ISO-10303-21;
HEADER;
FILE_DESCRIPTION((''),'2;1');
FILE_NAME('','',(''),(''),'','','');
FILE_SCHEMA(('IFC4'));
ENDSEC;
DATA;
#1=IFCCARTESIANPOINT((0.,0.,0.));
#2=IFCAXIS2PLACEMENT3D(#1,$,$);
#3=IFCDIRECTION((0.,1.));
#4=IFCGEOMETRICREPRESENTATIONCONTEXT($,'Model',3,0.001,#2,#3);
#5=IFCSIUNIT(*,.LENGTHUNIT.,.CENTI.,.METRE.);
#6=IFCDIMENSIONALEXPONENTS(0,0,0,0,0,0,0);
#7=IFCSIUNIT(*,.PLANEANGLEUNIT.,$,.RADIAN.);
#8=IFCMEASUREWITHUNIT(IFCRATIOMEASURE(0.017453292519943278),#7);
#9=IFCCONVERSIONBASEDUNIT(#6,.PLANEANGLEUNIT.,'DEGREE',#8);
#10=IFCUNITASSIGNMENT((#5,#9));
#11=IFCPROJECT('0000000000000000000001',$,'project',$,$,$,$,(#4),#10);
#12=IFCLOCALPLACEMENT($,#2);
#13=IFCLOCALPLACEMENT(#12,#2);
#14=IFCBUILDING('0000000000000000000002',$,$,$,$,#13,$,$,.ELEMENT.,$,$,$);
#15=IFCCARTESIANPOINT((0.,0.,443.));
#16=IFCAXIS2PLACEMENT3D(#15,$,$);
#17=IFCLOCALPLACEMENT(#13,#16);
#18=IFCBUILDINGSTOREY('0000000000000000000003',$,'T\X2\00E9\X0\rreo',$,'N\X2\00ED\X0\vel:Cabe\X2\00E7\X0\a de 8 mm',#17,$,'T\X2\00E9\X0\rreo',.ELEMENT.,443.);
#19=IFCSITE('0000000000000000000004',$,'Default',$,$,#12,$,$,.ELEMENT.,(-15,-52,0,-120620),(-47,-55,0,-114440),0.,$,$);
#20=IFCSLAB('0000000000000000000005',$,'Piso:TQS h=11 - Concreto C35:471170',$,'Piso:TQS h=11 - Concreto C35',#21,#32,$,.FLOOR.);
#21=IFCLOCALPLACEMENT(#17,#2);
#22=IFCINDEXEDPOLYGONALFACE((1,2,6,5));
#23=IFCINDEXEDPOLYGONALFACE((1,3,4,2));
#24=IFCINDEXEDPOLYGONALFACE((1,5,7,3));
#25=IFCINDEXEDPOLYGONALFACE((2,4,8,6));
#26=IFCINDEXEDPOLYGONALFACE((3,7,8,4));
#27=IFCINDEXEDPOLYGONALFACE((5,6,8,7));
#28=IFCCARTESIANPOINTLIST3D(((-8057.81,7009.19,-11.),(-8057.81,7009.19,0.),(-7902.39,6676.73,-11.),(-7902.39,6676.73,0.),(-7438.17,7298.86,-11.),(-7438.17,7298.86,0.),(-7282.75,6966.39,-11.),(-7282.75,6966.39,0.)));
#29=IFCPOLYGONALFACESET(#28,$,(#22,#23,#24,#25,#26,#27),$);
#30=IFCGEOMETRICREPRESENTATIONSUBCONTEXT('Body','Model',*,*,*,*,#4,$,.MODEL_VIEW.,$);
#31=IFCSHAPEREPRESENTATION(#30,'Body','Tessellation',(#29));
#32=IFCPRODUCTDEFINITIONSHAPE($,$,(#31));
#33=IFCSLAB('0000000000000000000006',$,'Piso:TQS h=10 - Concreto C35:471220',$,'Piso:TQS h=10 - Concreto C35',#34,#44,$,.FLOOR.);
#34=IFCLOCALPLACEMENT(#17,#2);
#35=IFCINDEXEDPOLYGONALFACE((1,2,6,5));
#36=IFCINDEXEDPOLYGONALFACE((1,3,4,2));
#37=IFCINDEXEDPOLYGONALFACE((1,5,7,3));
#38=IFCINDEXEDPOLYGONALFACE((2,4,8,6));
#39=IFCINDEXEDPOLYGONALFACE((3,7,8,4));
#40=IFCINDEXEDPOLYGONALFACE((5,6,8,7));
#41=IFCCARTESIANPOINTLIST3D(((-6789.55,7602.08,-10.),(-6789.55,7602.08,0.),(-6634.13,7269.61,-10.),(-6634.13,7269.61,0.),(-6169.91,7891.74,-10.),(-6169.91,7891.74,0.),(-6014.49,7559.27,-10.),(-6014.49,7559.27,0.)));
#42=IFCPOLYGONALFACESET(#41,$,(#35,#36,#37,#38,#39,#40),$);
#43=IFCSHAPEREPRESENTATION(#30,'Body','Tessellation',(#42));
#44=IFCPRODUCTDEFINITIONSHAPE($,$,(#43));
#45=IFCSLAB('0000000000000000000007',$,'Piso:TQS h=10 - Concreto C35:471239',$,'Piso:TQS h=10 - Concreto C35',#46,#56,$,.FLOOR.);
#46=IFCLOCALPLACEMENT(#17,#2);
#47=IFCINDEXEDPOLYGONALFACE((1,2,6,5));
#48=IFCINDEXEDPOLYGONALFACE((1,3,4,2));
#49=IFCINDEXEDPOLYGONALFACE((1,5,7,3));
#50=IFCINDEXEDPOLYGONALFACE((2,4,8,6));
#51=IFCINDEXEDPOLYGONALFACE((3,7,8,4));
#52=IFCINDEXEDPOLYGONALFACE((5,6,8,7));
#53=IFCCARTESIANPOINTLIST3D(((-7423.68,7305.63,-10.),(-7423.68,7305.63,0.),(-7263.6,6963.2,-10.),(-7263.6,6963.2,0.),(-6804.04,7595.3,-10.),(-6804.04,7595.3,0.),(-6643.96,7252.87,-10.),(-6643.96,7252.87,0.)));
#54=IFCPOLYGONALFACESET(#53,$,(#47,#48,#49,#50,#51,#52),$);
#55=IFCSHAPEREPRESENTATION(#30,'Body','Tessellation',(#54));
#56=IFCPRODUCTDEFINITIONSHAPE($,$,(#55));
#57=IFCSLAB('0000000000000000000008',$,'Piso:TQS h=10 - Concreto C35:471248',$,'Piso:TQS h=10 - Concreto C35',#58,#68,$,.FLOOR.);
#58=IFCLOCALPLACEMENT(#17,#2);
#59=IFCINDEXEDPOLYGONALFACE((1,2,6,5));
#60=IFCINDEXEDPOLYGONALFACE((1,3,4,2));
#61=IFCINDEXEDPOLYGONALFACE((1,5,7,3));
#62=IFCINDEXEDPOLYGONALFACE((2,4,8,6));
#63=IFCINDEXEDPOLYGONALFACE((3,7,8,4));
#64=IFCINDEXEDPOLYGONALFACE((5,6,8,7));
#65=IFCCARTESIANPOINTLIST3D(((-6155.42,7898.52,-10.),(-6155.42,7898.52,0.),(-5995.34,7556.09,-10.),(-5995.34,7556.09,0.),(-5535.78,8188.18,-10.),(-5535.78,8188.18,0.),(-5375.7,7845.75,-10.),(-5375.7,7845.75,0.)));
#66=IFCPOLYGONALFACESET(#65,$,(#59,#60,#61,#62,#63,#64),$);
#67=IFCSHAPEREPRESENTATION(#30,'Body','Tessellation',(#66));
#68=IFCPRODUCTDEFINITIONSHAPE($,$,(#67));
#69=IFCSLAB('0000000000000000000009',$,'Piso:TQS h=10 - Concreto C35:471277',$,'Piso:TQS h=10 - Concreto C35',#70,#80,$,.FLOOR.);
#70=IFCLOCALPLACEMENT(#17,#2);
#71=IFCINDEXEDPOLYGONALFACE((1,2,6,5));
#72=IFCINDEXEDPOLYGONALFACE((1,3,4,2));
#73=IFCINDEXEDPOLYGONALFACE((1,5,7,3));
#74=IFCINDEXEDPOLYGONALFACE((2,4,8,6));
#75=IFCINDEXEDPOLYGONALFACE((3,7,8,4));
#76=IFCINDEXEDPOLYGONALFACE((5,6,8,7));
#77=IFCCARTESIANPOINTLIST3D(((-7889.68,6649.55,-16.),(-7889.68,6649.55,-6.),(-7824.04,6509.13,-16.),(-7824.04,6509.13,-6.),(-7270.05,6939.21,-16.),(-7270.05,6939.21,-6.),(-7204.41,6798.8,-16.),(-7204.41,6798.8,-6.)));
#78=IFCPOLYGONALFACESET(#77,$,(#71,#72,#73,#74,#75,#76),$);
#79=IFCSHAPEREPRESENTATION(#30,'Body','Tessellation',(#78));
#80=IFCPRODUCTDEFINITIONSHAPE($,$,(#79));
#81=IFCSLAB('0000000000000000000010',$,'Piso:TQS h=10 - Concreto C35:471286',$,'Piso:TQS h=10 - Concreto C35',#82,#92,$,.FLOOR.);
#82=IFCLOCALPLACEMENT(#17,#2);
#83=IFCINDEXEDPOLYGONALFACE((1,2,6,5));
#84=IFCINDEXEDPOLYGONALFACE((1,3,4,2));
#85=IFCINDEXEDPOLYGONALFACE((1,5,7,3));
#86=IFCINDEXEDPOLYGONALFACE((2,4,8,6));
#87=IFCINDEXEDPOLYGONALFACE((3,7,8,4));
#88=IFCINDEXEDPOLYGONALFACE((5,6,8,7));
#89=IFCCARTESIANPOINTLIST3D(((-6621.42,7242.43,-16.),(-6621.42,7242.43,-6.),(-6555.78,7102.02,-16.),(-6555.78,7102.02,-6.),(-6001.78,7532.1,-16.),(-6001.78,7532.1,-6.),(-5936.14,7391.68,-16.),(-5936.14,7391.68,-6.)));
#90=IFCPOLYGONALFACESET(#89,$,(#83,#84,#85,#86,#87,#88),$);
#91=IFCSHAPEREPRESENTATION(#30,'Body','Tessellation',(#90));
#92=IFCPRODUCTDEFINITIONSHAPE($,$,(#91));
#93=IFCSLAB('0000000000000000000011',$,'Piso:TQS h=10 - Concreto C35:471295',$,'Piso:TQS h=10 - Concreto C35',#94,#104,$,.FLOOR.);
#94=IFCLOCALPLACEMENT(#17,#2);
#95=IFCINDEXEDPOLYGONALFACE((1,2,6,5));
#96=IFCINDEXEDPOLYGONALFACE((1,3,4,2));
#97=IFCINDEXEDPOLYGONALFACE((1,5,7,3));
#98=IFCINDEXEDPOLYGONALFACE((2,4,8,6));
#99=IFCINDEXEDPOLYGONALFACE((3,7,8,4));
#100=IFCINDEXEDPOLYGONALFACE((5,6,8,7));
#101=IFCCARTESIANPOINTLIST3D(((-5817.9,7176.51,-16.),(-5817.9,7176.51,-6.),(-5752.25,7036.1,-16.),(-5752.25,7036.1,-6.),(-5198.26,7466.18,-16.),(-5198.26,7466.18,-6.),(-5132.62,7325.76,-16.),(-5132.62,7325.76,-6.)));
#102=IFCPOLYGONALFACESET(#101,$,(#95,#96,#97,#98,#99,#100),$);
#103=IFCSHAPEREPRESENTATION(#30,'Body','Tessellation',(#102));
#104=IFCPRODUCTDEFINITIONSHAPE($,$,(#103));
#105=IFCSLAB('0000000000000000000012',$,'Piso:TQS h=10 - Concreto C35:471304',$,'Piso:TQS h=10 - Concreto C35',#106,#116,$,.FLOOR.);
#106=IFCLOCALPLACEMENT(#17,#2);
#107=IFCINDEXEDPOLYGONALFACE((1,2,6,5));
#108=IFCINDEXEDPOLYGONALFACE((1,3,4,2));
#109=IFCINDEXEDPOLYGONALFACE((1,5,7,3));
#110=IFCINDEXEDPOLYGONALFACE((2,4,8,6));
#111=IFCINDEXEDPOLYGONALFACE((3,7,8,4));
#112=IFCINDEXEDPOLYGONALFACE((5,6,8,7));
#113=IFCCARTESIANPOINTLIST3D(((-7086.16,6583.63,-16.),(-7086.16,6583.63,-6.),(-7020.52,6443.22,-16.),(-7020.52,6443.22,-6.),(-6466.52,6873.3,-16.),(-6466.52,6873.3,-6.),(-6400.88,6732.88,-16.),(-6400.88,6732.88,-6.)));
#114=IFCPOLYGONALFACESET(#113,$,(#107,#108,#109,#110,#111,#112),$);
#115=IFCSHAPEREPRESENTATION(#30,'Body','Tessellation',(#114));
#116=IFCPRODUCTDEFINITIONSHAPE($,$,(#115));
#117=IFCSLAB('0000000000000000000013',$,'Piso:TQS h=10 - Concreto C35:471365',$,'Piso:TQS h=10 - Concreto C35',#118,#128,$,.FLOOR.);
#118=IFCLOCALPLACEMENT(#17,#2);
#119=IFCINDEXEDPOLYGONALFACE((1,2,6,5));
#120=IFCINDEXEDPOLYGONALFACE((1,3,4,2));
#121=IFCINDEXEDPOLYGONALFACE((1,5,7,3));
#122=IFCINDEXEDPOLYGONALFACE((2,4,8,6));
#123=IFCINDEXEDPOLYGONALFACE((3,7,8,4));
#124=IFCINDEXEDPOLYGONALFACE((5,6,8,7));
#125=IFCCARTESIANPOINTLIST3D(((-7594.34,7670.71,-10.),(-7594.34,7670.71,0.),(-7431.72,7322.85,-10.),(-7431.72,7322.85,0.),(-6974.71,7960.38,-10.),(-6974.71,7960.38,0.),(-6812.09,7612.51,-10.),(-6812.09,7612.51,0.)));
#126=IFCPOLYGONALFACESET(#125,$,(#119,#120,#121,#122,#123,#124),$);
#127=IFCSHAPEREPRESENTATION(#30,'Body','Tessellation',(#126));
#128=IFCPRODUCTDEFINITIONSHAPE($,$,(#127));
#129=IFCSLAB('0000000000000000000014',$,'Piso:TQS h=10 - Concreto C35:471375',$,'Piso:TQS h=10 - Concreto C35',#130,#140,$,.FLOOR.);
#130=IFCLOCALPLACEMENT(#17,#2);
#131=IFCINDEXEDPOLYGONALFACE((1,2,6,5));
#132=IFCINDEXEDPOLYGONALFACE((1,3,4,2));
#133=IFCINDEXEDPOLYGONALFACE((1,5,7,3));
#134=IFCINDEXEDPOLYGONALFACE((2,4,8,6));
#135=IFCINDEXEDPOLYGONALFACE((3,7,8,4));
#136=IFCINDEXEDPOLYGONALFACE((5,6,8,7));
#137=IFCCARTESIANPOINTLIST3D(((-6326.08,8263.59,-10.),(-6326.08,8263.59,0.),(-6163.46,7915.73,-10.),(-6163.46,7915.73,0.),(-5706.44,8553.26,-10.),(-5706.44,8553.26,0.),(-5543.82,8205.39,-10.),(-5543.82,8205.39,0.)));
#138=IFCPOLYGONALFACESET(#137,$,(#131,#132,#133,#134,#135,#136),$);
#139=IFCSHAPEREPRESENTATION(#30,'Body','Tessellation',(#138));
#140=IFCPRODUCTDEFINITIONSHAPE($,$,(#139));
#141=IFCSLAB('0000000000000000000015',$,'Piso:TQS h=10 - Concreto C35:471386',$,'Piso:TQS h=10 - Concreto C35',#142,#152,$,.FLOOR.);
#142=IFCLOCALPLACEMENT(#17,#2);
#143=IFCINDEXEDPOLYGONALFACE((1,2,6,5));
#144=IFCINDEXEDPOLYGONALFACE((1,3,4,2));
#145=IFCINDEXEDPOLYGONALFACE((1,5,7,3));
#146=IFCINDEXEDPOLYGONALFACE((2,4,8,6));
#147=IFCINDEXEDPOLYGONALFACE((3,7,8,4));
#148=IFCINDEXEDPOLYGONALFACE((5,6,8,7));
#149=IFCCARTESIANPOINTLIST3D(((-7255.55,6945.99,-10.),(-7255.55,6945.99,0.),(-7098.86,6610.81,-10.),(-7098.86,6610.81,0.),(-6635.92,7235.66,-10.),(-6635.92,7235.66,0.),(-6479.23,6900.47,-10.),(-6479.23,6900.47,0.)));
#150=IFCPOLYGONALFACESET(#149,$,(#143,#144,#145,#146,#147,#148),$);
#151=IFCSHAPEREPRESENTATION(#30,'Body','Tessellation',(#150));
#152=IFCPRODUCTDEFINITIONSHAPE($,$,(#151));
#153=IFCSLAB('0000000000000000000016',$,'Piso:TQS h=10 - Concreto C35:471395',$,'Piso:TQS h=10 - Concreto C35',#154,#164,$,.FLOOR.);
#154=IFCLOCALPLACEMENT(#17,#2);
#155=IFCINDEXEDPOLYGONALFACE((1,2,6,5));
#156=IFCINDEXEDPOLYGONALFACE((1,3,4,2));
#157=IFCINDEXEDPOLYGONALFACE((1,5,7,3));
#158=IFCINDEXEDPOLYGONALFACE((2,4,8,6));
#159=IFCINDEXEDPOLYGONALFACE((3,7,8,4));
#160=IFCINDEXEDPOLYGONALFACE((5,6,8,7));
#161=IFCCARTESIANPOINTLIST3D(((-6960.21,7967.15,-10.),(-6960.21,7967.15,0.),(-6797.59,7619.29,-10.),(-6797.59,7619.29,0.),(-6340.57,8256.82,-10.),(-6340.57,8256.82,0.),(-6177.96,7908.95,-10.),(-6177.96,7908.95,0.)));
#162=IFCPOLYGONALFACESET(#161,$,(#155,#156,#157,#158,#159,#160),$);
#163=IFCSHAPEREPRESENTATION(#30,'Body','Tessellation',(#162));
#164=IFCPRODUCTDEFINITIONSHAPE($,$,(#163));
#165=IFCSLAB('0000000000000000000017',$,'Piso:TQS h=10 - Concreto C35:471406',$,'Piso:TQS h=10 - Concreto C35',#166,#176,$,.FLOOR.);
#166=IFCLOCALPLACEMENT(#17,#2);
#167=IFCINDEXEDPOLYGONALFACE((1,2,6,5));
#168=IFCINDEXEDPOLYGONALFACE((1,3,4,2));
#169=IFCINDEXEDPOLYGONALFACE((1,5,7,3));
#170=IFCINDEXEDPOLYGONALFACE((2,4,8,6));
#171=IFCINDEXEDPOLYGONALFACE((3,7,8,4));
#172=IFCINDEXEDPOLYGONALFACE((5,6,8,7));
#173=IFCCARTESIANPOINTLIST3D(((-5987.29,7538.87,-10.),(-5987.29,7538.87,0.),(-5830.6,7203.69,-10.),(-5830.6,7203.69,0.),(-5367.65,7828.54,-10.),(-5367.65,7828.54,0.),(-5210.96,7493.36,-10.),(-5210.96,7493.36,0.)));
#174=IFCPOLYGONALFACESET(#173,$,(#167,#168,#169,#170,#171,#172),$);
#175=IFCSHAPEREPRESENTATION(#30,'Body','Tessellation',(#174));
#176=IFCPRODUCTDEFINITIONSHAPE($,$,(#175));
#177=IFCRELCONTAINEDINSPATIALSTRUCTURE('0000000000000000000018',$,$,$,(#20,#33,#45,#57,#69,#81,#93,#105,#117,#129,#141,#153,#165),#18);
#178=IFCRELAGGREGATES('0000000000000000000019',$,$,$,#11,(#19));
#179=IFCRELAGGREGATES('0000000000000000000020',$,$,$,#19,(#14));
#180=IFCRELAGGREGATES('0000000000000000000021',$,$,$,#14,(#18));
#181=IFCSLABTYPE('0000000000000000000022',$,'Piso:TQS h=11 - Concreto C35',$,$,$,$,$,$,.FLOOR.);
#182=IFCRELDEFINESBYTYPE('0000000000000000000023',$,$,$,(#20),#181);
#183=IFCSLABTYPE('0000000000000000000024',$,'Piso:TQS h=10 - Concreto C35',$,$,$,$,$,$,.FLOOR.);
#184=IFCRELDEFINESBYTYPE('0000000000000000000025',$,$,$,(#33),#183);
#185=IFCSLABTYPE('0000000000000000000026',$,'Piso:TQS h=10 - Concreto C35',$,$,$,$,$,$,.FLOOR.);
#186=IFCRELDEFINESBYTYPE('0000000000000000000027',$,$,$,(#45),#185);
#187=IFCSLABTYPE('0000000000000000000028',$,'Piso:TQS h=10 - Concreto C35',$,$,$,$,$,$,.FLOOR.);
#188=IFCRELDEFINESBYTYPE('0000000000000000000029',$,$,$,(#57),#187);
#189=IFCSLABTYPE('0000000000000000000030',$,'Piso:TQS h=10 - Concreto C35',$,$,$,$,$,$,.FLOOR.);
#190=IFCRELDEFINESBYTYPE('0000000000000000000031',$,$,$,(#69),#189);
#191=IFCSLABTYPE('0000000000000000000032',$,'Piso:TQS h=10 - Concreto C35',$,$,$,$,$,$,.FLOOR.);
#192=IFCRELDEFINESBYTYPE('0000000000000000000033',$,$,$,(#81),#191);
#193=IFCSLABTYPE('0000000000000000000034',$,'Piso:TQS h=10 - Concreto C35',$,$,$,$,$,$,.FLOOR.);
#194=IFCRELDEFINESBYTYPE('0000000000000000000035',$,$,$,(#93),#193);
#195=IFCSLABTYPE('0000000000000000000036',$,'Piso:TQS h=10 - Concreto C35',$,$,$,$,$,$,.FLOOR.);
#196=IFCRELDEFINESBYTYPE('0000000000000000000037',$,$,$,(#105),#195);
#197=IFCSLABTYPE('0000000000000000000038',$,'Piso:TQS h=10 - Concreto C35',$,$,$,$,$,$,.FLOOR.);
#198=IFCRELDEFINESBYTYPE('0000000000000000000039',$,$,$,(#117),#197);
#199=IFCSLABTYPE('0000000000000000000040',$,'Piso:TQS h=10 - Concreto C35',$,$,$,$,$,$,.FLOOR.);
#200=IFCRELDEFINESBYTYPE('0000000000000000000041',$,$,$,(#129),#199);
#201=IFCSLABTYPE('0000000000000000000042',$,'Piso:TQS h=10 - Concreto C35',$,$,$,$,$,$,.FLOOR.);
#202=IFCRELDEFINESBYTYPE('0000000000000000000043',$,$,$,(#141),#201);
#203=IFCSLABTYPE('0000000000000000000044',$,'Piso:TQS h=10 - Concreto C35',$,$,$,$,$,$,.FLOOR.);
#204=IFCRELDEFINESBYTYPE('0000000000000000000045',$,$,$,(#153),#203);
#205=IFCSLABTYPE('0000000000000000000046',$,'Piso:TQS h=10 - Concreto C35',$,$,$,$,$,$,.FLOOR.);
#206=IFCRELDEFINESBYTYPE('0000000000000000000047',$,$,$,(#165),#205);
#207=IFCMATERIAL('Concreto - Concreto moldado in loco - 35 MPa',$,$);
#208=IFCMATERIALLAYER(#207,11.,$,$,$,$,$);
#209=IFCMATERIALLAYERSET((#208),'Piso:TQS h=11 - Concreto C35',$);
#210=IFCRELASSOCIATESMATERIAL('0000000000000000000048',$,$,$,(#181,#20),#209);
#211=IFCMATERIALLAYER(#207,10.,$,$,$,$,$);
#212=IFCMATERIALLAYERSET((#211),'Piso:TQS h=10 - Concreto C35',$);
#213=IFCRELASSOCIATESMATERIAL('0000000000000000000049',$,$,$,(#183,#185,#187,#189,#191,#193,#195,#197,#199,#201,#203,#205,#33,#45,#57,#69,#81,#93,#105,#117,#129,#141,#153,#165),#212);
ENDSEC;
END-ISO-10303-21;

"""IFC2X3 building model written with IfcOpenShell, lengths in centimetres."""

from ifc_helpers import new_model, entity, si_unit, converted_unit, direction, frame, frame_2d, origin, origin_2d_with_axis, place, context, subcontext, project, spatial, rectangle, extrude, material, layer, layer_set, layer_usage, type_object, element, save


model = new_model("IFC2X3")

# Units and contexts
model_context = context("Model", 3, precision=0.001, world=origin(), true_north=direction((0.0, 1.0)))
body_context = subcontext(model_context, "Body", "Model", "MODEL_VIEW")
ifc_project = project(units=[si_unit("LENGTHUNIT", "METRE", prefix="CENTI"), converted_unit("PLANEANGLEUNIT", "DEGREE", entity("IfcRatioMeasure", 0.017453292519943278), si_unit("PLANEANGLEUNIT", "RADIAN"), dimensions=[0, 0, 0, 0, 0, 0, 0])], contexts=[model_context])

# Site, building, storey
site_placement = place(None, origin())
site = spatial("IfcSite", under=ifc_project, at=site_placement, Name="Default", CompositionType="ELEMENT", RefLatitude=(-15, -52, 0, -120620), RefLongitude=(-47, -55, 0, -114440), RefElevation=0.0)
building_placement = place(site_placement, origin())
building = spatial("IfcBuilding", under=site, at=building_placement, CompositionType="ELEMENT")
storey_placement = place(building_placement, frame((0.0, 0.0, 443.0)))
storey = spatial("IfcBuildingStorey", under=building, at=storey_placement, Name="Térreo", ObjectType="Nível:Cabeça de 8 mm", LongName="Térreo", CompositionType="ELEMENT", Elevation=443.0)

# Slabs
ifc_material = material(Name="Concreto - Concreto moldado in loco - 35 MPa")
ifc_layer_1 = layer(ifc_material, 11.0)
ifc_layer_set_1 = layer_set([ifc_layer_1], Name="Piso:TQS h=11 - Concreto C35")
ifc_layer_usage_1 = layer_usage(ifc_layer_set_1, "AXIS3", "POSITIVE", 0.0)
slab_type_1 = type_object("IfcSlabType", Name="Piso:TQS h=11 - Concreto C35", PredefinedType="FLOOR", material=ifc_layer_set_1)
slab_1_placement = place(storey_placement, origin())
element("IfcSlab", 1, at=slab_1_placement, inside=storey, type_object=slab_type_1, material=ifc_layer_usage_1, Name="Piso:TQS h=11 - Concreto C35:471170", ObjectType="Piso:TQS h=11 - Concreto C35", PredefinedType="FLOOR", context=body_context, shape_type="SweptSolid", body=[
    extrude(rectangle(XDim=367.0, YDim=684.0, at=frame_2d((0.0, 0.0), x_axis=(1.0, 0.0))), frame((-7670.28, 6987.79, 0.0), z_axis=(0.0, 0.0, -1.0), x_axis=(0.423488, -0.905902, 0.0)), (0.0, 0.0, 1.0), 11.0),
])
ifc_layer_2 = layer(ifc_material, 10.0)
ifc_layer_set_2 = layer_set([ifc_layer_2], Name="Piso:TQS h=10 - Concreto C35")
ifc_layer_usage_2 = layer_usage(ifc_layer_set_2, "AXIS3", "POSITIVE", 0.0)
slab_type_2 = type_object("IfcSlabType", Name="Piso:TQS h=10 - Concreto C35", PredefinedType="FLOOR", material=ifc_layer_set_2)
slab_2_placement = place(storey_placement, origin())
element("IfcSlab", 2, at=slab_2_placement, inside=storey, type_object=slab_type_2, material=ifc_layer_usage_2, Name="Piso:TQS h=10 - Concreto C35:471220", ObjectType="Piso:TQS h=10 - Concreto C35", PredefinedType="FLOOR", context=body_context, shape_type="SweptSolid", body=[
    extrude(rectangle(XDim=684.0, YDim=367.0, at=frame_2d((0.0, 0.0), x_axis=(1.0, 0.0))), frame((-6402.02, 7580.68, 0.0), z_axis=(0.0, 0.0, -1.0), x_axis=(0.905902, 0.423488, 0.0)), (0.0, 0.0, 1.0), 10.0),
])
ifc_layer_usage_3 = layer_usage(ifc_layer_set_2, "AXIS3", "POSITIVE", 0.0)
slab_type_3 = type_object("IfcSlabType", Name="Piso:TQS h=10 - Concreto C35", PredefinedType="FLOOR", material=ifc_layer_set_2)
slab_3_placement = place(storey_placement, origin())
element("IfcSlab", 3, at=slab_3_placement, inside=storey, type_object=slab_type_3, material=ifc_layer_usage_3, Name="Piso:TQS h=10 - Concreto C35:471239", ObjectType="Piso:TQS h=10 - Concreto C35", PredefinedType="FLOOR", context=body_context, shape_type="SweptSolid", body=[
    extrude(rectangle(XDim=684.0, YDim=378.0, at=origin_2d_with_axis()), frame((-7033.82, 7279.25, 0.0), z_axis=(0.0, 0.0, -1.0), x_axis=(0.905902, 0.423488, 0.0)), (0.0, 0.0, 1.0), 10.0),
])
ifc_layer_usage_4 = layer_usage(ifc_layer_set_2, "AXIS3", "POSITIVE", 0.0)
slab_type_4 = type_object("IfcSlabType", Name="Piso:TQS h=10 - Concreto C35", PredefinedType="FLOOR", material=ifc_layer_set_2)
slab_4_placement = place(storey_placement, origin())
element("IfcSlab", 4, at=slab_4_placement, inside=storey, type_object=slab_type_4, material=ifc_layer_usage_4, Name="Piso:TQS h=10 - Concreto C35:471248", ObjectType="Piso:TQS h=10 - Concreto C35", PredefinedType="FLOOR", context=body_context, shape_type="SweptSolid", body=[
    extrude(rectangle(XDim=684.0, YDim=378.0, at=frame_2d((0.0, 0.0), x_axis=(1.0, 0.0))), frame((-5765.56, 7872.13, 0.0), z_axis=(0.0, 0.0, -1.0), x_axis=(0.905902, 0.423488, 0.0)), (0.0, 0.0, 1.0), 10.0),
])
ifc_layer_usage_5 = layer_usage(ifc_layer_set_2, "AXIS3", "POSITIVE", 0.0)
slab_type_5 = type_object("IfcSlabType", Name="Piso:TQS h=10 - Concreto C35", PredefinedType="FLOOR", material=ifc_layer_set_2)
slab_5_placement = place(storey_placement, origin())
element("IfcSlab", 5, at=slab_5_placement, inside=storey, type_object=slab_type_5, material=ifc_layer_usage_5, Name="Piso:TQS h=10 - Concreto C35:471277", ObjectType="Piso:TQS h=10 - Concreto C35", PredefinedType="FLOOR", context=body_context, shape_type="SweptSolid", body=[
    extrude(rectangle(XDim=155.0, YDim=684.0, at=frame_2d((0.0, 0.0), x_axis=(1.0, 0.0))), frame((-7547.05, 6724.17, -6.0), z_axis=(0.0, 0.0, -1.0), x_axis=(0.423488, -0.905902, 0.0)), (0.0, 0.0, 1.0), 10.0),
])
ifc_layer_usage_6 = layer_usage(ifc_layer_set_2, "AXIS3", "POSITIVE", 0.0)
slab_type_6 = type_object("IfcSlabType", Name="Piso:TQS h=10 - Concreto C35", PredefinedType="FLOOR", material=ifc_layer_set_2)
slab_6_placement = place(storey_placement, origin())
element("IfcSlab", 6, at=slab_6_placement, inside=storey, type_object=slab_type_6, material=ifc_layer_usage_6, Name="Piso:TQS h=10 - Concreto C35:471286", ObjectType="Piso:TQS h=10 - Concreto C35", PredefinedType="FLOOR", context=body_context, shape_type="SweptSolid", body=[
    extrude(rectangle(XDim=155.0, YDim=684.0, at=origin_2d_with_axis()), frame((-6278.78, 7317.06, -6.0), z_axis=(0.0, 0.0, -1.0), x_axis=(0.423488, -0.905902, 0.0)), (0.0, 0.0, 1.0), 10.0),
])
ifc_layer_usage_7 = layer_usage(ifc_layer_set_2, "AXIS3", "POSITIVE", 0.0)
slab_type_7 = type_object("IfcSlabType", Name="Piso:TQS h=10 - Concreto C35", PredefinedType="FLOOR", material=ifc_layer_set_2)
slab_7_placement = place(storey_placement, origin())
element("IfcSlab", 7, at=slab_7_placement, inside=storey, type_object=slab_type_7, material=ifc_layer_usage_7, Name="Piso:TQS h=10 - Concreto C35:471295", ObjectType="Piso:TQS h=10 - Concreto C35", PredefinedType="FLOOR", context=body_context, shape_type="SweptSolid", body=[
    extrude(rectangle(XDim=684.0, YDim=155.0, at=frame_2d((0.0, 0.0), x_axis=(1.0, 0.0))), frame((-5475.26, 7251.14, -6.0), z_axis=(0.0, 0.0, -1.0), x_axis=(0.905902, 0.423488, 0.0)), (0.0, 0.0, 1.0), 10.0),
])
ifc_layer_usage_8 = layer_usage(ifc_layer_set_2, "AXIS3", "POSITIVE", 0.0)
slab_type_8 = type_object("IfcSlabType", Name="Piso:TQS h=10 - Concreto C35", PredefinedType="FLOOR", material=ifc_layer_set_2)
slab_8_placement = place(storey_placement, origin())
element("IfcSlab", 8, at=slab_8_placement, inside=storey, type_object=slab_type_8, material=ifc_layer_usage_8, Name="Piso:TQS h=10 - Concreto C35:471304", ObjectType="Piso:TQS h=10 - Concreto C35", PredefinedType="FLOOR", context=body_context, shape_type="SweptSolid", body=[
    extrude(rectangle(XDim=684.0, YDim=155.0, at=origin_2d_with_axis()), frame((-6743.52, 6658.26, -6.0), z_axis=(0.0, 0.0, -1.0), x_axis=(0.905902, 0.423488, 0.0)), (0.0, 0.0, 1.0), 10.0),
])
ifc_layer_usage_9 = layer_usage(ifc_layer_set_2, "AXIS3", "POSITIVE", 0.0)
slab_type_9 = type_object("IfcSlabType", Name="Piso:TQS h=10 - Concreto C35", PredefinedType="FLOOR", material=ifc_layer_set_2)
slab_9_placement = place(storey_placement, origin())
element("IfcSlab", 9, at=slab_9_placement, inside=storey, type_object=slab_type_9, material=ifc_layer_usage_9, Name="Piso:TQS h=10 - Concreto C35:471365", ObjectType="Piso:TQS h=10 - Concreto C35", PredefinedType="FLOOR", context=body_context, shape_type="SweptSolid", body=[
    extrude(rectangle(XDim=684.0, YDim=384.0, at=frame_2d((0.0, 0.0), x_axis=(1.0, 0.0))), frame((-7203.22, 7641.61, 0.0), z_axis=(0.0, 0.0, -1.0), x_axis=(0.905902, 0.423488, 0.0)), (0.0, 0.0, 1.0), 10.0),
])
ifc_layer_usage_10 = layer_usage(ifc_layer_set_2, "AXIS3", "POSITIVE", 0.0)
slab_type_10 = type_object("IfcSlabType", Name="Piso:TQS h=10 - Concreto C35", PredefinedType="FLOOR", material=ifc_layer_set_2)
slab_10_placement = place(storey_placement, origin())
element("IfcSlab", 10, at=slab_10_placement, inside=storey, type_object=slab_type_10, material=ifc_layer_usage_10, Name="Piso:TQS h=10 - Concreto C35:471375", ObjectType="Piso:TQS h=10 - Concreto C35", PredefinedType="FLOOR", context=body_context, shape_type="SweptSolid", body=[
    extrude(rectangle(XDim=684.0, YDim=384.0, at=frame_2d((0.0, 0.0), x_axis=(1.0, 0.0))), frame((-5934.95, 8234.49, 0.0), z_axis=(0.0, 0.0, -1.0), x_axis=(0.905902, 0.423488, 0.0)), (0.0, 0.0, 1.0), 10.0),
])
ifc_layer_usage_11 = layer_usage(ifc_layer_set_2, "AXIS3", "POSITIVE", 0.0)
slab_type_11 = type_object("IfcSlabType", Name="Piso:TQS h=10 - Concreto C35", PredefinedType="FLOOR", material=ifc_layer_set_2)
slab_11_placement = place(storey_placement, origin())
element("IfcSlab", 11, at=slab_11_placement, inside=storey, type_object=slab_type_11, material=ifc_layer_usage_11, Name="Piso:TQS h=10 - Concreto C35:471386", ObjectType="Piso:TQS h=10 - Concreto C35", PredefinedType="FLOOR", context=body_context, shape_type="SweptSolid", body=[
    extrude(rectangle(XDim=370.0, YDim=684.0, at=frame_2d((0.0, 0.0), x_axis=(1.0, 0.0))), frame((-6867.39, 6923.23, 0.0), z_axis=(0.0, 0.0, -1.0), x_axis=(0.423488, -0.905902, 0.0)), (0.0, 0.0, 1.0), 10.0),
])
ifc_layer_usage_12 = layer_usage(ifc_layer_set_2, "AXIS3", "POSITIVE", 0.0)
slab_type_12 = type_object("IfcSlabType", Name="Piso:TQS h=10 - Concreto C35", PredefinedType="FLOOR", material=ifc_layer_set_2)
slab_12_placement = place(storey_placement, origin())
element("IfcSlab", 12, at=slab_12_placement, inside=storey, type_object=slab_type_12, material=ifc_layer_usage_12, Name="Piso:TQS h=10 - Concreto C35:471395", ObjectType="Piso:TQS h=10 - Concreto C35", PredefinedType="FLOOR", context=body_context, shape_type="SweptSolid", body=[
    extrude(rectangle(XDim=684.0, YDim=384.0, at=frame_2d((0.0, 0.0), x_axis=(1.0, 0.0))), frame((-6569.08, 7938.05, 0.0), z_axis=(0.0, 0.0, -1.0), x_axis=(0.905902, 0.423488, 0.0)), (0.0, 0.0, 1.0), 10.0),
])
ifc_layer_usage_13 = layer_usage(ifc_layer_set_2, "AXIS3", "POSITIVE", 0.0)
slab_type_13 = type_object("IfcSlabType", Name="Piso:TQS h=10 - Concreto C35", PredefinedType="FLOOR", material=ifc_layer_set_2)
slab_13_placement = place(storey_placement, origin())
element("IfcSlab", 13, at=slab_13_placement, inside=storey, type_object=slab_type_13, material=ifc_layer_usage_13, Name="Piso:TQS h=10 - Concreto C35:471406", ObjectType="Piso:TQS h=10 - Concreto C35", PredefinedType="FLOOR", context=body_context, shape_type="SweptSolid", body=[
    extrude(rectangle(XDim=370.0, YDim=684.0, at=frame_2d((0.0, 0.0), x_axis=(1.0, 0.0))), frame((-5599.13, 7516.11, 0.0), z_axis=(0.0, 0.0, -1.0), x_axis=(0.423488, -0.905902, 0.0)), (0.0, 0.0, 1.0), 10.0),
])

save(model, "model.ifc")
